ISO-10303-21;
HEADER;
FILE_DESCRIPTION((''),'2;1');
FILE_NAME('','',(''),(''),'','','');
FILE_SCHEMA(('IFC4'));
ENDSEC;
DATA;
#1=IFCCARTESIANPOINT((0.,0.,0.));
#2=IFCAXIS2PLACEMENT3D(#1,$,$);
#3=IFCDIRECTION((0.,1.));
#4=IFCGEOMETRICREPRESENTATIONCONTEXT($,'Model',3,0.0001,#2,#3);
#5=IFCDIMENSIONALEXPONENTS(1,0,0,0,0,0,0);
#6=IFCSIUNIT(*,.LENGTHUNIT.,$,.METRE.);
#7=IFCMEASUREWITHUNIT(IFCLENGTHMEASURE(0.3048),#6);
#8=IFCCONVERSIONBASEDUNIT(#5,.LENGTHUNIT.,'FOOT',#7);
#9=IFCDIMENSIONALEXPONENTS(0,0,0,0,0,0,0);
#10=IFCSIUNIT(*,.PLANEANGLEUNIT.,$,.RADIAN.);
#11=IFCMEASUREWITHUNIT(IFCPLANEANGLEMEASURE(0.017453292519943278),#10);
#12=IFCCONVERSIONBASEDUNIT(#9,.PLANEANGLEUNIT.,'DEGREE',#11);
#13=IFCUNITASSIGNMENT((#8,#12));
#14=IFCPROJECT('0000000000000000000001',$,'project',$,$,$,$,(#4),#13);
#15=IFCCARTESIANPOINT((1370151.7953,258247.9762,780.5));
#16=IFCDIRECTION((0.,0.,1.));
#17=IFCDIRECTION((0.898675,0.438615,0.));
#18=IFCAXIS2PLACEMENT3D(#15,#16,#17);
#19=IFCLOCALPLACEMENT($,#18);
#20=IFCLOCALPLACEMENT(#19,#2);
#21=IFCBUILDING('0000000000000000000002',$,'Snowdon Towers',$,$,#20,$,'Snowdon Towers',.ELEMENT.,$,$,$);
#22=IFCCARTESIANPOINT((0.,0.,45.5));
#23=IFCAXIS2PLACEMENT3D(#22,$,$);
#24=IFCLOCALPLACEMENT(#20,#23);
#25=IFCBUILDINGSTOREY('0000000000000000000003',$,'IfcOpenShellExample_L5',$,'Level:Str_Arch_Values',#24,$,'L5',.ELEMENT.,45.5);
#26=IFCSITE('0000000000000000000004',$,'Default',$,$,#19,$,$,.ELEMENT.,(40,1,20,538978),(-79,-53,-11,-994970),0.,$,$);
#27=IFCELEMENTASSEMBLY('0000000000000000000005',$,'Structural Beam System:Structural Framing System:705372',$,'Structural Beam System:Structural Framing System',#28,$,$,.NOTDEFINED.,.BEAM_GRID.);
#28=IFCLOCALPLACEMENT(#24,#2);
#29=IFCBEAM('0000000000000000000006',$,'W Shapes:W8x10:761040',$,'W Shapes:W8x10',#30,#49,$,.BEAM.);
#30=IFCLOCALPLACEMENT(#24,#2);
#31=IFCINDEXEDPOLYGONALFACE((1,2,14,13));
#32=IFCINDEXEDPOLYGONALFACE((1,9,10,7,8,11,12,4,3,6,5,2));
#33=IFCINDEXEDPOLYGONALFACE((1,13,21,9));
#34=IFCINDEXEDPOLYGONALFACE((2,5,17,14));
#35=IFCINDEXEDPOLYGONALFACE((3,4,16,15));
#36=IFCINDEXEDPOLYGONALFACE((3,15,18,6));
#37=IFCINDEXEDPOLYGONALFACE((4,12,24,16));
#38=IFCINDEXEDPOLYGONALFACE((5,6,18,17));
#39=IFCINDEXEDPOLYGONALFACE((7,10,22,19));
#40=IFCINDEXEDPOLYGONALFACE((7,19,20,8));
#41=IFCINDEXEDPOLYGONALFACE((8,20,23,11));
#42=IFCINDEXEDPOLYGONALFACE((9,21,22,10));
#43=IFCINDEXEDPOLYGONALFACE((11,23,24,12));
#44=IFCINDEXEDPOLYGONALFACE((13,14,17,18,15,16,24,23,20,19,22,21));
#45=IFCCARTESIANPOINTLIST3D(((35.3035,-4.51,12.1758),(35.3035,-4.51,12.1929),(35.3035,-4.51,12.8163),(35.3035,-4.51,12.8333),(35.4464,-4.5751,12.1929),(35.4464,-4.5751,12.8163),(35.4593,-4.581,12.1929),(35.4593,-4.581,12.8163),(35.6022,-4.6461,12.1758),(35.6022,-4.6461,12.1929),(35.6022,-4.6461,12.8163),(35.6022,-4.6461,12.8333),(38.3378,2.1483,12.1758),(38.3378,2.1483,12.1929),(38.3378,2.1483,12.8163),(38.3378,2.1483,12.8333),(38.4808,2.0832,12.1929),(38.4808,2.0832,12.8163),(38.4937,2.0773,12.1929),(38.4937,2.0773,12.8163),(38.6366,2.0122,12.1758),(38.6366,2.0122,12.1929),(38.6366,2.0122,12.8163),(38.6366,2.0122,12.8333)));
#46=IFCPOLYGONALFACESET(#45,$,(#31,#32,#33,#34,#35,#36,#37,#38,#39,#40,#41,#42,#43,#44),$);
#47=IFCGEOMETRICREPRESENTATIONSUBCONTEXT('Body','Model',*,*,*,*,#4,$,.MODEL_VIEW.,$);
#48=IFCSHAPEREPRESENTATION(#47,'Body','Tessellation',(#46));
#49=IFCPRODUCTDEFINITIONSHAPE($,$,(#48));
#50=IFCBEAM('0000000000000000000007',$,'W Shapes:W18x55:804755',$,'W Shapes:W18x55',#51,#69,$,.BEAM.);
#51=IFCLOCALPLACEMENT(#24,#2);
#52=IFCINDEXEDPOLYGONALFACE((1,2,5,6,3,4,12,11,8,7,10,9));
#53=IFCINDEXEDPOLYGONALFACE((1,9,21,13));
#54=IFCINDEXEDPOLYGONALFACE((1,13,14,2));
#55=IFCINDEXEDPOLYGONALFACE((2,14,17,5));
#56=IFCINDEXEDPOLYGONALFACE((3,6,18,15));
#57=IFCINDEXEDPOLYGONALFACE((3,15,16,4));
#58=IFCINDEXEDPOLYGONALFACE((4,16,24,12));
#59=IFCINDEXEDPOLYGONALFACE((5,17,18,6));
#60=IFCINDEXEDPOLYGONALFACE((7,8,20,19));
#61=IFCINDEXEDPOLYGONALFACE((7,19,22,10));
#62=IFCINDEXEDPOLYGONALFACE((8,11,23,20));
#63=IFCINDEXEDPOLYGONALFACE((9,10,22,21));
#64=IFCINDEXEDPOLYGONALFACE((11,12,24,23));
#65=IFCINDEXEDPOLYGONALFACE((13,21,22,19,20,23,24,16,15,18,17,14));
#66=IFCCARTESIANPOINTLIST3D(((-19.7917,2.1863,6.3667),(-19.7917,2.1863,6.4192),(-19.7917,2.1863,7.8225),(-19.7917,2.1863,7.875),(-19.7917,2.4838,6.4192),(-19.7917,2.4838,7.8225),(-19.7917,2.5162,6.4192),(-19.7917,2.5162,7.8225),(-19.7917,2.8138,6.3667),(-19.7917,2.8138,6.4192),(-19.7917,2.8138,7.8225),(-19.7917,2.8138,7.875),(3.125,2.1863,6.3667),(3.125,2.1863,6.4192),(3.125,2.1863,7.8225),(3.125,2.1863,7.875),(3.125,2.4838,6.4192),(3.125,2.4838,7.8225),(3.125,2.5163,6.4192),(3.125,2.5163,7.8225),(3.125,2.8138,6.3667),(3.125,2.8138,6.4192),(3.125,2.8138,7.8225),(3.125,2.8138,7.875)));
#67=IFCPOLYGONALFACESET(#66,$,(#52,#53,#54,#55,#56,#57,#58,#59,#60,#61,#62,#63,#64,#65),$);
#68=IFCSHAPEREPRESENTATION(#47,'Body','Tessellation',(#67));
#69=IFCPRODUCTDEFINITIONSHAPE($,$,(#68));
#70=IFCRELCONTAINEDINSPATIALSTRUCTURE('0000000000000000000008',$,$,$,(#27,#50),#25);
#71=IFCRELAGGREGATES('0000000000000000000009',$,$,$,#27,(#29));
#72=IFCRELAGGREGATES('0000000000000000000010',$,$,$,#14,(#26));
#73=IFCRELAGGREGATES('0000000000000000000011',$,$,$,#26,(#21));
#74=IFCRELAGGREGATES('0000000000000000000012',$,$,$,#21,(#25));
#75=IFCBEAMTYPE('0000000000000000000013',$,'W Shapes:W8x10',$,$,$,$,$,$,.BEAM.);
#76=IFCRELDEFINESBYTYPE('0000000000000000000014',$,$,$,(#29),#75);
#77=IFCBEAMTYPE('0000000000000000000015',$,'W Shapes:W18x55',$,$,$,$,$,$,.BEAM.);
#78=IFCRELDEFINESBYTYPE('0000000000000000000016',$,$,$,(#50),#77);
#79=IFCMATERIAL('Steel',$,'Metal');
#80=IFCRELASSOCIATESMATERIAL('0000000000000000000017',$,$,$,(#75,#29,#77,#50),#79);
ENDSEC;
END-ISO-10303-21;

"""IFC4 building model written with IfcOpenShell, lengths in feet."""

from ifc_helpers import new_model, entity, si_unit, converted_unit, direction, frame, origin, place, context, subcontext, project, spatial, indexed_curve, outline, extrude, source, transform, mapped, material, type_object, type_shapes, element, aggregate, save


model = new_model("IFC4")

# Units and contexts
model_context = context("Model", 3, precision=0.0001, world=origin(), true_north=direction((0.0, 1.0)))
body_context = subcontext(model_context, "Body", "Model", "MODEL_VIEW")
ifc_project = project(units=[converted_unit("LENGTHUNIT", "FOOT", entity("IfcLengthMeasure", 0.3048), si_unit("LENGTHUNIT", "METRE"), dimensions=[1, 0, 0, 0, 0, 0, 0]), converted_unit("PLANEANGLEUNIT", "DEGREE", entity("IfcPlaneAngleMeasure", 0.017453292519943278), si_unit("PLANEANGLEUNIT", "RADIAN"), dimensions=[0, 0, 0, 0, 0, 0, 0])], contexts=[model_context])

# Site, building, storey
site_placement = place(None, frame((1370151.7953, 258247.9762, 780.5), z_axis=(0.0, 0.0, 1.0), x_axis=(0.898675, 0.438615, 0.0)))
site = spatial("IfcSite", under=ifc_project, at=site_placement, Name="Default", CompositionType="ELEMENT", RefLatitude=(40, 1, 20, 538978), RefLongitude=(-79, -53, -11, -994970), RefElevation=0.0)
building_placement = place(site_placement, origin())
building = spatial("IfcBuilding", under=site, at=building_placement, Name="Snowdon Towers", LongName="Snowdon Towers", CompositionType="ELEMENT")
storey_placement = place(building_placement, frame((0.0, 0.0, 45.5)))
storey = spatial("IfcBuildingStorey", under=building, at=storey_placement, Name="IfcOpenShellExample_L5", ObjectType="Level:Str_Arch_Values", LongName="L5", CompositionType="ELEMENT", Elevation=45.5)

# Shared definitions
ifc_material = material(Name="Steel", Category="Metal")

# Element assembly
assembly_1_placement = place(storey_placement, origin())
assembly_1 = element("IfcElementAssembly", 1, at=assembly_1_placement, inside=storey, Name="Structural Beam System:Structural Framing System:705372", ObjectType="Structural Beam System:Structural Framing System", AssemblyPlace="NOTDEFINED", PredefinedType="BEAM_GRID")

# Beams
beam_type_1 = type_object("IfcBeamType", Name="W Shapes:W8x10", PredefinedType="BEAM", material=ifc_material)
shared_shape_1 = source(origin(), body_context, "Body", "SweptSolid", [
    extrude(outline(indexed_curve([(-0.1642, -0.3117), (-0.1642, -0.3288), (0.1642, -0.3288), (0.1642, -0.3117), (0.0071, -0.3117), (0.0071, 0.3117), (0.1642, 0.3117), (0.1642, 0.3287), (-0.1642, 0.3287), (-0.1642, 0.3117), (-0.0071, 0.3117), (-0.0071, -0.3117), (-0.1642, -0.3117)], self_intersect=False)), frame((-3.7332, 0.0, 0.0), z_axis=(-1.0, 0.0, 0.0), x_axis=(0.0, -1.0, 0.0)), (0.0, 0.0, -1.0), 7.3171),
])
type_shapes(beam_type_1, [shared_shape_1])
beam_1_placement = place(assembly_1_placement, frame((37.001, -1.181, 12.5046), z_axis=(0.0, 0.0, 1.0), x_axis=(0.414693, 0.909961, 0.0)))
beam_1 = element("IfcBeam", 2, at=beam_1_placement, type_object=beam_type_1, material=ifc_material, Name="W Shapes:W8x10:761040", ObjectType="W Shapes:W8x10", PredefinedType="BEAM", context=body_context, shape_type="MappedRepresentation", body=[
    mapped(shared_shape_1, transform((0.0, 0.0, 0.0), scale=1.0)),
])
aggregate(assembly_1, [beam_1])
beam_type_2 = type_object("IfcBeamType", Name="W Shapes:W18x55", PredefinedType="BEAM", material=ifc_material)
shared_shape_2 = source(origin(), body_context, "Body", "SweptSolid", [
    extrude(outline(indexed_curve([(-0.3138, -0.7017), (-0.3138, -0.7542), (0.3138, -0.7542), (0.3138, -0.7017), (0.0162, -0.7017), (0.0162, 0.7017), (0.3138, 0.7017), (0.3138, 0.7542), (-0.3137, 0.7542), (-0.3137, 0.7017), (-0.0163, 0.7017), (-0.0163, -0.7017), (-0.3138, -0.7017)], self_intersect=False)), frame((-11.4583, 0.0, 0.0), z_axis=(-1.0, 0.0, 0.0), x_axis=(0.0, -1.0, 0.0)), (0.0, 0.0, -1.0), 22.9167),
])
type_shapes(beam_type_2, [shared_shape_2])
beam_2_placement = place(storey_placement, frame((-8.3333, 2.5, 7.1208)))
element("IfcBeam", 3, at=beam_2_placement, inside=storey, type_object=beam_type_2, material=ifc_material, Name="W Shapes:W18x55:804755", ObjectType="W Shapes:W18x55", PredefinedType="BEAM", context=body_context, shape_type="MappedRepresentation", body=[
    mapped(shared_shape_2, transform((0.0, 0.0, 0.0), scale=1.0)),
])

save(model, "model.ifc")
